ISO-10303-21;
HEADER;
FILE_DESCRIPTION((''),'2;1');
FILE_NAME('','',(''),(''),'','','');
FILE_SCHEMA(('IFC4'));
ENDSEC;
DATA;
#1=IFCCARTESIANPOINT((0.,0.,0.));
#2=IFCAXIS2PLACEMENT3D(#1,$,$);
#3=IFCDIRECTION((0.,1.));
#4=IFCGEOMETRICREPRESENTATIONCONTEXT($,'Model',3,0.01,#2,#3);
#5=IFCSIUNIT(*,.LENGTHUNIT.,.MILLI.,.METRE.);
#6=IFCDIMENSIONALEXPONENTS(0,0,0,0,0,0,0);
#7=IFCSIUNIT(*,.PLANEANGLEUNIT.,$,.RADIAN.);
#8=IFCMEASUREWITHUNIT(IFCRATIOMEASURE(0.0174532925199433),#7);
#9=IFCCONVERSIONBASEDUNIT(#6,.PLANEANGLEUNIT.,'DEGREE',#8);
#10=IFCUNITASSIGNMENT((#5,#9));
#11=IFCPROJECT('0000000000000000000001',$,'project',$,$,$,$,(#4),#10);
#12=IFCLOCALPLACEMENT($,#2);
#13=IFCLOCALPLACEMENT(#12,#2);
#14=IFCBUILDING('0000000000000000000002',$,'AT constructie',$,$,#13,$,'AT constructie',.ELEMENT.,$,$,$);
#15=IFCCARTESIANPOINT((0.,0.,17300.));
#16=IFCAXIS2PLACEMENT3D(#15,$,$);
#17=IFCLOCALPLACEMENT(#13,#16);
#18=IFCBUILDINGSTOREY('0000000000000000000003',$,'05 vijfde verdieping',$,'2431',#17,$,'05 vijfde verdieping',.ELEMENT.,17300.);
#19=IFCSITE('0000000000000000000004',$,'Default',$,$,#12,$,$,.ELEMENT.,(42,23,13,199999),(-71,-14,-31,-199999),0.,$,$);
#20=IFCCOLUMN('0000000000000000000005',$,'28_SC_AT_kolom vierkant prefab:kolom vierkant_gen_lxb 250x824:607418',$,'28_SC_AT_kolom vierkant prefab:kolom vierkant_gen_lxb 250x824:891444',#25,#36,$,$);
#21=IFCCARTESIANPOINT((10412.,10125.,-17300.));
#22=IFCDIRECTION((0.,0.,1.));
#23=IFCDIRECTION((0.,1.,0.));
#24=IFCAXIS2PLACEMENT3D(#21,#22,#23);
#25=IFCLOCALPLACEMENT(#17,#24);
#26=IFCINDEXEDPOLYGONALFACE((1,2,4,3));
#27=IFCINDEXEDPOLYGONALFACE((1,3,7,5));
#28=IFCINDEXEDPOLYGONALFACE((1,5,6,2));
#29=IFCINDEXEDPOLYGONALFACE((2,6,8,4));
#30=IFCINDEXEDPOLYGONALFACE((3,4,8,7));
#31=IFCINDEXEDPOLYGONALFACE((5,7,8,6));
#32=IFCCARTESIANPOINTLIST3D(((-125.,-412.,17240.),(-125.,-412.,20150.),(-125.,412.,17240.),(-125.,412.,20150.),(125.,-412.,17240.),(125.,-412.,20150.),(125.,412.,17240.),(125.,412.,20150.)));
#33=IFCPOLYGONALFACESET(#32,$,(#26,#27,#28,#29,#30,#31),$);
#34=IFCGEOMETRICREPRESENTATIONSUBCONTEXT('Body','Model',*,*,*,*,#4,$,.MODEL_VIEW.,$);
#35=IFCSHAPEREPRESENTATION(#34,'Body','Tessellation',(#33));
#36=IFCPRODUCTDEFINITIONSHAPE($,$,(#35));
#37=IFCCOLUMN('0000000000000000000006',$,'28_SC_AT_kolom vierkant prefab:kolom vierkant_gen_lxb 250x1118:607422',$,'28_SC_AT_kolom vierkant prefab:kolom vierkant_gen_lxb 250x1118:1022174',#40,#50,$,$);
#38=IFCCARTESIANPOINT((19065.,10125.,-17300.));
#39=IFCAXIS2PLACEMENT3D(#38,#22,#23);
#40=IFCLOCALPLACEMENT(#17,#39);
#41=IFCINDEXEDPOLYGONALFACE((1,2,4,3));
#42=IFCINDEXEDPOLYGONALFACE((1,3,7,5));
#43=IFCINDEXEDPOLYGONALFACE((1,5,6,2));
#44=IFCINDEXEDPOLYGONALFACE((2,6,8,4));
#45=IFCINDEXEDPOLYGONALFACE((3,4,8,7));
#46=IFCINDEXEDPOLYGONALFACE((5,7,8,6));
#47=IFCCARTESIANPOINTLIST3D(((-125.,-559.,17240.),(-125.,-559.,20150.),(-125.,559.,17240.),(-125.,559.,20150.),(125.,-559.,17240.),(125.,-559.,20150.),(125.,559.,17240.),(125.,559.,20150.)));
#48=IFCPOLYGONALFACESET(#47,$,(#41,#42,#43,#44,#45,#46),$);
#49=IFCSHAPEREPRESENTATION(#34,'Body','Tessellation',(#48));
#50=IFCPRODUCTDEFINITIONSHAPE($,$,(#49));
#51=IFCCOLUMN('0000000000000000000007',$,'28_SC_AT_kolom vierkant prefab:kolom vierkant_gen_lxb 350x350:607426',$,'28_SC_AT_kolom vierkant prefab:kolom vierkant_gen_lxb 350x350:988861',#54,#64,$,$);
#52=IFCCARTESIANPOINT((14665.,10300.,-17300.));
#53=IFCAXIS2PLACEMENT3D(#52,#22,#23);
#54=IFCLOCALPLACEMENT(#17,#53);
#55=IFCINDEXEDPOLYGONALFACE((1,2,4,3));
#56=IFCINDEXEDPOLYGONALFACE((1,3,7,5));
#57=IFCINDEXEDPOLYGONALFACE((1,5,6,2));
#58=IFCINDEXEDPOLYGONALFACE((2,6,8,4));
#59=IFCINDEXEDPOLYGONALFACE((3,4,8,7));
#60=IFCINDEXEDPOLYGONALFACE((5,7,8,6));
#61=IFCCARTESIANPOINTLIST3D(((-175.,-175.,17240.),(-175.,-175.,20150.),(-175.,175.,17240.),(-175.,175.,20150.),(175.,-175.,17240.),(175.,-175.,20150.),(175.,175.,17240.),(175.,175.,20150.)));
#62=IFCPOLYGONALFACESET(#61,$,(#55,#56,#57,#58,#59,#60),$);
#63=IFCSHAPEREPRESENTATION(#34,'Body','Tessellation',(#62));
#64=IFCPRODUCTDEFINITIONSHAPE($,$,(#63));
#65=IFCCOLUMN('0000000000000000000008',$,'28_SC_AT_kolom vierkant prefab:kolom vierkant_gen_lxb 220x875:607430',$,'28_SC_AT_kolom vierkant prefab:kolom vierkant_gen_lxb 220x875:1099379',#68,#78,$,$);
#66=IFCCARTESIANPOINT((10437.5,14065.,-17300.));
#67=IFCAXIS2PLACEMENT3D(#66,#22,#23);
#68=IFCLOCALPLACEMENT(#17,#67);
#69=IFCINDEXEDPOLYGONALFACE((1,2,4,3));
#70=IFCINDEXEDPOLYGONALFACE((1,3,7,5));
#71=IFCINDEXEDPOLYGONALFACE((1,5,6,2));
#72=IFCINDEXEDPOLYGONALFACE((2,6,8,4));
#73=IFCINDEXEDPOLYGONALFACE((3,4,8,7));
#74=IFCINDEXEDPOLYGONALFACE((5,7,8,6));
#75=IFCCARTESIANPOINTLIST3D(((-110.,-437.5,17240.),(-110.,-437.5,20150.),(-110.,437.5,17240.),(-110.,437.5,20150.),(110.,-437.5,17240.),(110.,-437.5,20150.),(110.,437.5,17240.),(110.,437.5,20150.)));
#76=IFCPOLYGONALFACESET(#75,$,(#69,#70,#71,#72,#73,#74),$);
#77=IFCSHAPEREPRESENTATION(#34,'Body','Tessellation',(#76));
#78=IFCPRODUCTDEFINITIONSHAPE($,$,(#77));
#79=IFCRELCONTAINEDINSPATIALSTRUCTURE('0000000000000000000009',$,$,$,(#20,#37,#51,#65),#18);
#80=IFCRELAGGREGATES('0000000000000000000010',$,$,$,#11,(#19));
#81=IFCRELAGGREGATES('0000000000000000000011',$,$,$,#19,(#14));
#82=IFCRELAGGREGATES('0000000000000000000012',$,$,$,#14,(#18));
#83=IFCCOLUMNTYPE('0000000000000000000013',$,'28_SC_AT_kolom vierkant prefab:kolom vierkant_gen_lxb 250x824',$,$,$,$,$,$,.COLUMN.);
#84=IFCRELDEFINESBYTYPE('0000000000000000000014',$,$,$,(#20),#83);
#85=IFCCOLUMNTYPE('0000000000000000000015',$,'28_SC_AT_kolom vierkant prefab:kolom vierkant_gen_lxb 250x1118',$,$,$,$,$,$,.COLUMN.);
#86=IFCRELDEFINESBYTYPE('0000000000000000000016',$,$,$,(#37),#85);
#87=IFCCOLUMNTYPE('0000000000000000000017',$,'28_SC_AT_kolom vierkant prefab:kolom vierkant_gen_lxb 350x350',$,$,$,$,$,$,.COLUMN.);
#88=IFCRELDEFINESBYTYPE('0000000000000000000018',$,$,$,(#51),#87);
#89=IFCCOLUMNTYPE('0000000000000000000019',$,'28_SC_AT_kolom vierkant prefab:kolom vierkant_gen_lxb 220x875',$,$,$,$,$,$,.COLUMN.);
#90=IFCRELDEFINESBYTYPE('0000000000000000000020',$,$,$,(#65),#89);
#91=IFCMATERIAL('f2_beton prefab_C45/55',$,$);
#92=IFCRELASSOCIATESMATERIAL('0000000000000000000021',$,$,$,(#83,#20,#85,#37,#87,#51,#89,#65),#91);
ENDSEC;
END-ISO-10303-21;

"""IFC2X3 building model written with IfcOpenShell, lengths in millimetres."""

from ifc_helpers import new_model, entity, si_unit, converted_unit, direction, frame, origin, origin_2d_with_axis, place, context, subcontext, project, spatial, rectangle, extrude, source, transform, mapped, material, type_object, type_shapes, element, save


model = new_model("IFC2X3")

# Units and contexts
model_context = context("Model", 3, precision=0.01, world=origin(), true_north=direction((0.0, 1.0)))
body_context = subcontext(model_context, "Body", "Model", "MODEL_VIEW")
ifc_project = project(units=[si_unit("LENGTHUNIT", "METRE", prefix="MILLI"), converted_unit("PLANEANGLEUNIT", "DEGREE", entity("IfcRatioMeasure", 0.0174532925199433), si_unit("PLANEANGLEUNIT", "RADIAN"), dimensions=[0, 0, 0, 0, 0, 0, 0])], contexts=[model_context])

# Site, building, storey
site_placement = place(None, origin())
site = spatial("IfcSite", under=ifc_project, at=site_placement, Name="Default", CompositionType="ELEMENT", RefLatitude=(42, 23, 13, 199999), RefLongitude=(-71, -14, -31, -199999), RefElevation=0.0)
building_placement = place(site_placement, origin())
building = spatial("IfcBuilding", under=site, at=building_placement, Name="AT constructie", LongName="AT constructie", CompositionType="ELEMENT")
storey_placement = place(building_placement, frame((0.0, 0.0, 17300.0)))
storey = spatial("IfcBuildingStorey", under=building, at=storey_placement, Name="05 vijfde verdieping", ObjectType="2431", LongName="05 vijfde verdieping", CompositionType="ELEMENT", Elevation=17300.0)

# Columns
ifc_material = material(Name="f2_beton prefab_C45/55")
column_type_1 = type_object("IfcColumnType", Name="28_SC_AT_kolom vierkant prefab:kolom vierkant_gen_lxb 250x824", PredefinedType="COLUMN", material=ifc_material)
shared_shape_1 = source(origin(), body_context, "Body", "SweptSolid", [
    extrude(rectangle(XDim=250.0, YDim=824.0, at=origin_2d_with_axis()), frame((0.0, 0.0, 17240.0), z_axis=(0.0, 0.0, 1.0), x_axis=(-1.0, 0.0, 0.0)), (0.0, 0.0, 1.0), 2910.0),
])
type_shapes(column_type_1, [shared_shape_1])
column_1_placement = place(storey_placement, frame((10412.0, 10125.0, -17300.0), z_axis=(0.0, 0.0, 1.0), x_axis=(0.0, 1.0, 0.0)))
element("IfcColumn", 1, at=column_1_placement, inside=storey, type_object=column_type_1, material=ifc_material, Name="28_SC_AT_kolom vierkant prefab:kolom vierkant_gen_lxb 250x824:607418", ObjectType="28_SC_AT_kolom vierkant prefab:kolom vierkant_gen_lxb 250x824:891444", context=body_context, shape_type="MappedRepresentation", body=[
    mapped(shared_shape_1, transform((0.0, 0.0, 0.0), scale=1.0)),
])
column_type_2 = type_object("IfcColumnType", Name="28_SC_AT_kolom vierkant prefab:kolom vierkant_gen_lxb 250x1118", PredefinedType="COLUMN", material=ifc_material)
shared_shape_2 = source(origin(), body_context, "Body", "SweptSolid", [
    extrude(rectangle(XDim=250.0, YDim=1118.0, at=origin_2d_with_axis()), frame((0.0, 0.0, 17240.0), z_axis=(0.0, 0.0, 1.0), x_axis=(-1.0, 0.0, 0.0)), (0.0, 0.0, 1.0), 2910.0),
])
type_shapes(column_type_2, [shared_shape_2])
column_2_placement = place(storey_placement, frame((19065.0, 10125.0, -17300.0), z_axis=(0.0, 0.0, 1.0), x_axis=(0.0, 1.0, 0.0)))
element("IfcColumn", 2, at=column_2_placement, inside=storey, type_object=column_type_2, material=ifc_material, Name="28_SC_AT_kolom vierkant prefab:kolom vierkant_gen_lxb 250x1118:607422", ObjectType="28_SC_AT_kolom vierkant prefab:kolom vierkant_gen_lxb 250x1118:1022174", context=body_context, shape_type="MappedRepresentation", body=[
    mapped(shared_shape_2, transform((0.0, 0.0, 0.0), scale=1.0)),
])
column_type_3 = type_object("IfcColumnType", Name="28_SC_AT_kolom vierkant prefab:kolom vierkant_gen_lxb 350x350", PredefinedType="COLUMN", material=ifc_material)
shared_shape_3 = source(origin(), body_context, "Body", "SweptSolid", [
    extrude(rectangle(XDim=350.0, YDim=350.0, at=origin_2d_with_axis()), frame((0.0, 0.0, 17240.0), z_axis=(0.0, 0.0, 1.0), x_axis=(-1.0, 0.0, 0.0)), (0.0, 0.0, 1.0), 2910.0),
])
type_shapes(column_type_3, [shared_shape_3])
column_3_placement = place(storey_placement, frame((14665.0, 10300.0, -17300.0), z_axis=(0.0, 0.0, 1.0), x_axis=(0.0, 1.0, 0.0)))
element("IfcColumn", 3, at=column_3_placement, inside=storey, type_object=column_type_3, material=ifc_material, Name="28_SC_AT_kolom vierkant prefab:kolom vierkant_gen_lxb 350x350:607426", ObjectType="28_SC_AT_kolom vierkant prefab:kolom vierkant_gen_lxb 350x350:988861", context=body_context, shape_type="MappedRepresentation", body=[
    mapped(shared_shape_3, transform((0.0, 0.0, 0.0), scale=1.0)),
])
column_type_4 = type_object("IfcColumnType", Name="28_SC_AT_kolom vierkant prefab:kolom vierkant_gen_lxb 220x875", PredefinedType="COLUMN", material=ifc_material)
shared_shape_4 = source(origin(), body_context, "Body", "SweptSolid", [
    extrude(rectangle(XDim=220.0, YDim=875.0, at=origin_2d_with_axis()), frame((0.0, 0.0, 17240.0), z_axis=(0.0, 0.0, 1.0), x_axis=(-1.0, 0.0, 0.0)), (0.0, 0.0, 1.0), 2910.0),
])
type_shapes(column_type_4, [shared_shape_4])
column_4_placement = place(storey_placement, frame((10437.5, 14065.0, -17300.0), z_axis=(0.0, 0.0, 1.0), x_axis=(0.0, 1.0, 0.0)))
element("IfcColumn", 4, at=column_4_placement, inside=storey, type_object=column_type_4, material=ifc_material, Name="28_SC_AT_kolom vierkant prefab:kolom vierkant_gen_lxb 220x875:607430", ObjectType="28_SC_AT_kolom vierkant prefab:kolom vierkant_gen_lxb 220x875:1099379", context=body_context, shape_type="MappedRepresentation", body=[
    mapped(shared_shape_4, transform((0.0, 0.0, 0.0), scale=1.0)),
])

save(model, "model.ifc")
